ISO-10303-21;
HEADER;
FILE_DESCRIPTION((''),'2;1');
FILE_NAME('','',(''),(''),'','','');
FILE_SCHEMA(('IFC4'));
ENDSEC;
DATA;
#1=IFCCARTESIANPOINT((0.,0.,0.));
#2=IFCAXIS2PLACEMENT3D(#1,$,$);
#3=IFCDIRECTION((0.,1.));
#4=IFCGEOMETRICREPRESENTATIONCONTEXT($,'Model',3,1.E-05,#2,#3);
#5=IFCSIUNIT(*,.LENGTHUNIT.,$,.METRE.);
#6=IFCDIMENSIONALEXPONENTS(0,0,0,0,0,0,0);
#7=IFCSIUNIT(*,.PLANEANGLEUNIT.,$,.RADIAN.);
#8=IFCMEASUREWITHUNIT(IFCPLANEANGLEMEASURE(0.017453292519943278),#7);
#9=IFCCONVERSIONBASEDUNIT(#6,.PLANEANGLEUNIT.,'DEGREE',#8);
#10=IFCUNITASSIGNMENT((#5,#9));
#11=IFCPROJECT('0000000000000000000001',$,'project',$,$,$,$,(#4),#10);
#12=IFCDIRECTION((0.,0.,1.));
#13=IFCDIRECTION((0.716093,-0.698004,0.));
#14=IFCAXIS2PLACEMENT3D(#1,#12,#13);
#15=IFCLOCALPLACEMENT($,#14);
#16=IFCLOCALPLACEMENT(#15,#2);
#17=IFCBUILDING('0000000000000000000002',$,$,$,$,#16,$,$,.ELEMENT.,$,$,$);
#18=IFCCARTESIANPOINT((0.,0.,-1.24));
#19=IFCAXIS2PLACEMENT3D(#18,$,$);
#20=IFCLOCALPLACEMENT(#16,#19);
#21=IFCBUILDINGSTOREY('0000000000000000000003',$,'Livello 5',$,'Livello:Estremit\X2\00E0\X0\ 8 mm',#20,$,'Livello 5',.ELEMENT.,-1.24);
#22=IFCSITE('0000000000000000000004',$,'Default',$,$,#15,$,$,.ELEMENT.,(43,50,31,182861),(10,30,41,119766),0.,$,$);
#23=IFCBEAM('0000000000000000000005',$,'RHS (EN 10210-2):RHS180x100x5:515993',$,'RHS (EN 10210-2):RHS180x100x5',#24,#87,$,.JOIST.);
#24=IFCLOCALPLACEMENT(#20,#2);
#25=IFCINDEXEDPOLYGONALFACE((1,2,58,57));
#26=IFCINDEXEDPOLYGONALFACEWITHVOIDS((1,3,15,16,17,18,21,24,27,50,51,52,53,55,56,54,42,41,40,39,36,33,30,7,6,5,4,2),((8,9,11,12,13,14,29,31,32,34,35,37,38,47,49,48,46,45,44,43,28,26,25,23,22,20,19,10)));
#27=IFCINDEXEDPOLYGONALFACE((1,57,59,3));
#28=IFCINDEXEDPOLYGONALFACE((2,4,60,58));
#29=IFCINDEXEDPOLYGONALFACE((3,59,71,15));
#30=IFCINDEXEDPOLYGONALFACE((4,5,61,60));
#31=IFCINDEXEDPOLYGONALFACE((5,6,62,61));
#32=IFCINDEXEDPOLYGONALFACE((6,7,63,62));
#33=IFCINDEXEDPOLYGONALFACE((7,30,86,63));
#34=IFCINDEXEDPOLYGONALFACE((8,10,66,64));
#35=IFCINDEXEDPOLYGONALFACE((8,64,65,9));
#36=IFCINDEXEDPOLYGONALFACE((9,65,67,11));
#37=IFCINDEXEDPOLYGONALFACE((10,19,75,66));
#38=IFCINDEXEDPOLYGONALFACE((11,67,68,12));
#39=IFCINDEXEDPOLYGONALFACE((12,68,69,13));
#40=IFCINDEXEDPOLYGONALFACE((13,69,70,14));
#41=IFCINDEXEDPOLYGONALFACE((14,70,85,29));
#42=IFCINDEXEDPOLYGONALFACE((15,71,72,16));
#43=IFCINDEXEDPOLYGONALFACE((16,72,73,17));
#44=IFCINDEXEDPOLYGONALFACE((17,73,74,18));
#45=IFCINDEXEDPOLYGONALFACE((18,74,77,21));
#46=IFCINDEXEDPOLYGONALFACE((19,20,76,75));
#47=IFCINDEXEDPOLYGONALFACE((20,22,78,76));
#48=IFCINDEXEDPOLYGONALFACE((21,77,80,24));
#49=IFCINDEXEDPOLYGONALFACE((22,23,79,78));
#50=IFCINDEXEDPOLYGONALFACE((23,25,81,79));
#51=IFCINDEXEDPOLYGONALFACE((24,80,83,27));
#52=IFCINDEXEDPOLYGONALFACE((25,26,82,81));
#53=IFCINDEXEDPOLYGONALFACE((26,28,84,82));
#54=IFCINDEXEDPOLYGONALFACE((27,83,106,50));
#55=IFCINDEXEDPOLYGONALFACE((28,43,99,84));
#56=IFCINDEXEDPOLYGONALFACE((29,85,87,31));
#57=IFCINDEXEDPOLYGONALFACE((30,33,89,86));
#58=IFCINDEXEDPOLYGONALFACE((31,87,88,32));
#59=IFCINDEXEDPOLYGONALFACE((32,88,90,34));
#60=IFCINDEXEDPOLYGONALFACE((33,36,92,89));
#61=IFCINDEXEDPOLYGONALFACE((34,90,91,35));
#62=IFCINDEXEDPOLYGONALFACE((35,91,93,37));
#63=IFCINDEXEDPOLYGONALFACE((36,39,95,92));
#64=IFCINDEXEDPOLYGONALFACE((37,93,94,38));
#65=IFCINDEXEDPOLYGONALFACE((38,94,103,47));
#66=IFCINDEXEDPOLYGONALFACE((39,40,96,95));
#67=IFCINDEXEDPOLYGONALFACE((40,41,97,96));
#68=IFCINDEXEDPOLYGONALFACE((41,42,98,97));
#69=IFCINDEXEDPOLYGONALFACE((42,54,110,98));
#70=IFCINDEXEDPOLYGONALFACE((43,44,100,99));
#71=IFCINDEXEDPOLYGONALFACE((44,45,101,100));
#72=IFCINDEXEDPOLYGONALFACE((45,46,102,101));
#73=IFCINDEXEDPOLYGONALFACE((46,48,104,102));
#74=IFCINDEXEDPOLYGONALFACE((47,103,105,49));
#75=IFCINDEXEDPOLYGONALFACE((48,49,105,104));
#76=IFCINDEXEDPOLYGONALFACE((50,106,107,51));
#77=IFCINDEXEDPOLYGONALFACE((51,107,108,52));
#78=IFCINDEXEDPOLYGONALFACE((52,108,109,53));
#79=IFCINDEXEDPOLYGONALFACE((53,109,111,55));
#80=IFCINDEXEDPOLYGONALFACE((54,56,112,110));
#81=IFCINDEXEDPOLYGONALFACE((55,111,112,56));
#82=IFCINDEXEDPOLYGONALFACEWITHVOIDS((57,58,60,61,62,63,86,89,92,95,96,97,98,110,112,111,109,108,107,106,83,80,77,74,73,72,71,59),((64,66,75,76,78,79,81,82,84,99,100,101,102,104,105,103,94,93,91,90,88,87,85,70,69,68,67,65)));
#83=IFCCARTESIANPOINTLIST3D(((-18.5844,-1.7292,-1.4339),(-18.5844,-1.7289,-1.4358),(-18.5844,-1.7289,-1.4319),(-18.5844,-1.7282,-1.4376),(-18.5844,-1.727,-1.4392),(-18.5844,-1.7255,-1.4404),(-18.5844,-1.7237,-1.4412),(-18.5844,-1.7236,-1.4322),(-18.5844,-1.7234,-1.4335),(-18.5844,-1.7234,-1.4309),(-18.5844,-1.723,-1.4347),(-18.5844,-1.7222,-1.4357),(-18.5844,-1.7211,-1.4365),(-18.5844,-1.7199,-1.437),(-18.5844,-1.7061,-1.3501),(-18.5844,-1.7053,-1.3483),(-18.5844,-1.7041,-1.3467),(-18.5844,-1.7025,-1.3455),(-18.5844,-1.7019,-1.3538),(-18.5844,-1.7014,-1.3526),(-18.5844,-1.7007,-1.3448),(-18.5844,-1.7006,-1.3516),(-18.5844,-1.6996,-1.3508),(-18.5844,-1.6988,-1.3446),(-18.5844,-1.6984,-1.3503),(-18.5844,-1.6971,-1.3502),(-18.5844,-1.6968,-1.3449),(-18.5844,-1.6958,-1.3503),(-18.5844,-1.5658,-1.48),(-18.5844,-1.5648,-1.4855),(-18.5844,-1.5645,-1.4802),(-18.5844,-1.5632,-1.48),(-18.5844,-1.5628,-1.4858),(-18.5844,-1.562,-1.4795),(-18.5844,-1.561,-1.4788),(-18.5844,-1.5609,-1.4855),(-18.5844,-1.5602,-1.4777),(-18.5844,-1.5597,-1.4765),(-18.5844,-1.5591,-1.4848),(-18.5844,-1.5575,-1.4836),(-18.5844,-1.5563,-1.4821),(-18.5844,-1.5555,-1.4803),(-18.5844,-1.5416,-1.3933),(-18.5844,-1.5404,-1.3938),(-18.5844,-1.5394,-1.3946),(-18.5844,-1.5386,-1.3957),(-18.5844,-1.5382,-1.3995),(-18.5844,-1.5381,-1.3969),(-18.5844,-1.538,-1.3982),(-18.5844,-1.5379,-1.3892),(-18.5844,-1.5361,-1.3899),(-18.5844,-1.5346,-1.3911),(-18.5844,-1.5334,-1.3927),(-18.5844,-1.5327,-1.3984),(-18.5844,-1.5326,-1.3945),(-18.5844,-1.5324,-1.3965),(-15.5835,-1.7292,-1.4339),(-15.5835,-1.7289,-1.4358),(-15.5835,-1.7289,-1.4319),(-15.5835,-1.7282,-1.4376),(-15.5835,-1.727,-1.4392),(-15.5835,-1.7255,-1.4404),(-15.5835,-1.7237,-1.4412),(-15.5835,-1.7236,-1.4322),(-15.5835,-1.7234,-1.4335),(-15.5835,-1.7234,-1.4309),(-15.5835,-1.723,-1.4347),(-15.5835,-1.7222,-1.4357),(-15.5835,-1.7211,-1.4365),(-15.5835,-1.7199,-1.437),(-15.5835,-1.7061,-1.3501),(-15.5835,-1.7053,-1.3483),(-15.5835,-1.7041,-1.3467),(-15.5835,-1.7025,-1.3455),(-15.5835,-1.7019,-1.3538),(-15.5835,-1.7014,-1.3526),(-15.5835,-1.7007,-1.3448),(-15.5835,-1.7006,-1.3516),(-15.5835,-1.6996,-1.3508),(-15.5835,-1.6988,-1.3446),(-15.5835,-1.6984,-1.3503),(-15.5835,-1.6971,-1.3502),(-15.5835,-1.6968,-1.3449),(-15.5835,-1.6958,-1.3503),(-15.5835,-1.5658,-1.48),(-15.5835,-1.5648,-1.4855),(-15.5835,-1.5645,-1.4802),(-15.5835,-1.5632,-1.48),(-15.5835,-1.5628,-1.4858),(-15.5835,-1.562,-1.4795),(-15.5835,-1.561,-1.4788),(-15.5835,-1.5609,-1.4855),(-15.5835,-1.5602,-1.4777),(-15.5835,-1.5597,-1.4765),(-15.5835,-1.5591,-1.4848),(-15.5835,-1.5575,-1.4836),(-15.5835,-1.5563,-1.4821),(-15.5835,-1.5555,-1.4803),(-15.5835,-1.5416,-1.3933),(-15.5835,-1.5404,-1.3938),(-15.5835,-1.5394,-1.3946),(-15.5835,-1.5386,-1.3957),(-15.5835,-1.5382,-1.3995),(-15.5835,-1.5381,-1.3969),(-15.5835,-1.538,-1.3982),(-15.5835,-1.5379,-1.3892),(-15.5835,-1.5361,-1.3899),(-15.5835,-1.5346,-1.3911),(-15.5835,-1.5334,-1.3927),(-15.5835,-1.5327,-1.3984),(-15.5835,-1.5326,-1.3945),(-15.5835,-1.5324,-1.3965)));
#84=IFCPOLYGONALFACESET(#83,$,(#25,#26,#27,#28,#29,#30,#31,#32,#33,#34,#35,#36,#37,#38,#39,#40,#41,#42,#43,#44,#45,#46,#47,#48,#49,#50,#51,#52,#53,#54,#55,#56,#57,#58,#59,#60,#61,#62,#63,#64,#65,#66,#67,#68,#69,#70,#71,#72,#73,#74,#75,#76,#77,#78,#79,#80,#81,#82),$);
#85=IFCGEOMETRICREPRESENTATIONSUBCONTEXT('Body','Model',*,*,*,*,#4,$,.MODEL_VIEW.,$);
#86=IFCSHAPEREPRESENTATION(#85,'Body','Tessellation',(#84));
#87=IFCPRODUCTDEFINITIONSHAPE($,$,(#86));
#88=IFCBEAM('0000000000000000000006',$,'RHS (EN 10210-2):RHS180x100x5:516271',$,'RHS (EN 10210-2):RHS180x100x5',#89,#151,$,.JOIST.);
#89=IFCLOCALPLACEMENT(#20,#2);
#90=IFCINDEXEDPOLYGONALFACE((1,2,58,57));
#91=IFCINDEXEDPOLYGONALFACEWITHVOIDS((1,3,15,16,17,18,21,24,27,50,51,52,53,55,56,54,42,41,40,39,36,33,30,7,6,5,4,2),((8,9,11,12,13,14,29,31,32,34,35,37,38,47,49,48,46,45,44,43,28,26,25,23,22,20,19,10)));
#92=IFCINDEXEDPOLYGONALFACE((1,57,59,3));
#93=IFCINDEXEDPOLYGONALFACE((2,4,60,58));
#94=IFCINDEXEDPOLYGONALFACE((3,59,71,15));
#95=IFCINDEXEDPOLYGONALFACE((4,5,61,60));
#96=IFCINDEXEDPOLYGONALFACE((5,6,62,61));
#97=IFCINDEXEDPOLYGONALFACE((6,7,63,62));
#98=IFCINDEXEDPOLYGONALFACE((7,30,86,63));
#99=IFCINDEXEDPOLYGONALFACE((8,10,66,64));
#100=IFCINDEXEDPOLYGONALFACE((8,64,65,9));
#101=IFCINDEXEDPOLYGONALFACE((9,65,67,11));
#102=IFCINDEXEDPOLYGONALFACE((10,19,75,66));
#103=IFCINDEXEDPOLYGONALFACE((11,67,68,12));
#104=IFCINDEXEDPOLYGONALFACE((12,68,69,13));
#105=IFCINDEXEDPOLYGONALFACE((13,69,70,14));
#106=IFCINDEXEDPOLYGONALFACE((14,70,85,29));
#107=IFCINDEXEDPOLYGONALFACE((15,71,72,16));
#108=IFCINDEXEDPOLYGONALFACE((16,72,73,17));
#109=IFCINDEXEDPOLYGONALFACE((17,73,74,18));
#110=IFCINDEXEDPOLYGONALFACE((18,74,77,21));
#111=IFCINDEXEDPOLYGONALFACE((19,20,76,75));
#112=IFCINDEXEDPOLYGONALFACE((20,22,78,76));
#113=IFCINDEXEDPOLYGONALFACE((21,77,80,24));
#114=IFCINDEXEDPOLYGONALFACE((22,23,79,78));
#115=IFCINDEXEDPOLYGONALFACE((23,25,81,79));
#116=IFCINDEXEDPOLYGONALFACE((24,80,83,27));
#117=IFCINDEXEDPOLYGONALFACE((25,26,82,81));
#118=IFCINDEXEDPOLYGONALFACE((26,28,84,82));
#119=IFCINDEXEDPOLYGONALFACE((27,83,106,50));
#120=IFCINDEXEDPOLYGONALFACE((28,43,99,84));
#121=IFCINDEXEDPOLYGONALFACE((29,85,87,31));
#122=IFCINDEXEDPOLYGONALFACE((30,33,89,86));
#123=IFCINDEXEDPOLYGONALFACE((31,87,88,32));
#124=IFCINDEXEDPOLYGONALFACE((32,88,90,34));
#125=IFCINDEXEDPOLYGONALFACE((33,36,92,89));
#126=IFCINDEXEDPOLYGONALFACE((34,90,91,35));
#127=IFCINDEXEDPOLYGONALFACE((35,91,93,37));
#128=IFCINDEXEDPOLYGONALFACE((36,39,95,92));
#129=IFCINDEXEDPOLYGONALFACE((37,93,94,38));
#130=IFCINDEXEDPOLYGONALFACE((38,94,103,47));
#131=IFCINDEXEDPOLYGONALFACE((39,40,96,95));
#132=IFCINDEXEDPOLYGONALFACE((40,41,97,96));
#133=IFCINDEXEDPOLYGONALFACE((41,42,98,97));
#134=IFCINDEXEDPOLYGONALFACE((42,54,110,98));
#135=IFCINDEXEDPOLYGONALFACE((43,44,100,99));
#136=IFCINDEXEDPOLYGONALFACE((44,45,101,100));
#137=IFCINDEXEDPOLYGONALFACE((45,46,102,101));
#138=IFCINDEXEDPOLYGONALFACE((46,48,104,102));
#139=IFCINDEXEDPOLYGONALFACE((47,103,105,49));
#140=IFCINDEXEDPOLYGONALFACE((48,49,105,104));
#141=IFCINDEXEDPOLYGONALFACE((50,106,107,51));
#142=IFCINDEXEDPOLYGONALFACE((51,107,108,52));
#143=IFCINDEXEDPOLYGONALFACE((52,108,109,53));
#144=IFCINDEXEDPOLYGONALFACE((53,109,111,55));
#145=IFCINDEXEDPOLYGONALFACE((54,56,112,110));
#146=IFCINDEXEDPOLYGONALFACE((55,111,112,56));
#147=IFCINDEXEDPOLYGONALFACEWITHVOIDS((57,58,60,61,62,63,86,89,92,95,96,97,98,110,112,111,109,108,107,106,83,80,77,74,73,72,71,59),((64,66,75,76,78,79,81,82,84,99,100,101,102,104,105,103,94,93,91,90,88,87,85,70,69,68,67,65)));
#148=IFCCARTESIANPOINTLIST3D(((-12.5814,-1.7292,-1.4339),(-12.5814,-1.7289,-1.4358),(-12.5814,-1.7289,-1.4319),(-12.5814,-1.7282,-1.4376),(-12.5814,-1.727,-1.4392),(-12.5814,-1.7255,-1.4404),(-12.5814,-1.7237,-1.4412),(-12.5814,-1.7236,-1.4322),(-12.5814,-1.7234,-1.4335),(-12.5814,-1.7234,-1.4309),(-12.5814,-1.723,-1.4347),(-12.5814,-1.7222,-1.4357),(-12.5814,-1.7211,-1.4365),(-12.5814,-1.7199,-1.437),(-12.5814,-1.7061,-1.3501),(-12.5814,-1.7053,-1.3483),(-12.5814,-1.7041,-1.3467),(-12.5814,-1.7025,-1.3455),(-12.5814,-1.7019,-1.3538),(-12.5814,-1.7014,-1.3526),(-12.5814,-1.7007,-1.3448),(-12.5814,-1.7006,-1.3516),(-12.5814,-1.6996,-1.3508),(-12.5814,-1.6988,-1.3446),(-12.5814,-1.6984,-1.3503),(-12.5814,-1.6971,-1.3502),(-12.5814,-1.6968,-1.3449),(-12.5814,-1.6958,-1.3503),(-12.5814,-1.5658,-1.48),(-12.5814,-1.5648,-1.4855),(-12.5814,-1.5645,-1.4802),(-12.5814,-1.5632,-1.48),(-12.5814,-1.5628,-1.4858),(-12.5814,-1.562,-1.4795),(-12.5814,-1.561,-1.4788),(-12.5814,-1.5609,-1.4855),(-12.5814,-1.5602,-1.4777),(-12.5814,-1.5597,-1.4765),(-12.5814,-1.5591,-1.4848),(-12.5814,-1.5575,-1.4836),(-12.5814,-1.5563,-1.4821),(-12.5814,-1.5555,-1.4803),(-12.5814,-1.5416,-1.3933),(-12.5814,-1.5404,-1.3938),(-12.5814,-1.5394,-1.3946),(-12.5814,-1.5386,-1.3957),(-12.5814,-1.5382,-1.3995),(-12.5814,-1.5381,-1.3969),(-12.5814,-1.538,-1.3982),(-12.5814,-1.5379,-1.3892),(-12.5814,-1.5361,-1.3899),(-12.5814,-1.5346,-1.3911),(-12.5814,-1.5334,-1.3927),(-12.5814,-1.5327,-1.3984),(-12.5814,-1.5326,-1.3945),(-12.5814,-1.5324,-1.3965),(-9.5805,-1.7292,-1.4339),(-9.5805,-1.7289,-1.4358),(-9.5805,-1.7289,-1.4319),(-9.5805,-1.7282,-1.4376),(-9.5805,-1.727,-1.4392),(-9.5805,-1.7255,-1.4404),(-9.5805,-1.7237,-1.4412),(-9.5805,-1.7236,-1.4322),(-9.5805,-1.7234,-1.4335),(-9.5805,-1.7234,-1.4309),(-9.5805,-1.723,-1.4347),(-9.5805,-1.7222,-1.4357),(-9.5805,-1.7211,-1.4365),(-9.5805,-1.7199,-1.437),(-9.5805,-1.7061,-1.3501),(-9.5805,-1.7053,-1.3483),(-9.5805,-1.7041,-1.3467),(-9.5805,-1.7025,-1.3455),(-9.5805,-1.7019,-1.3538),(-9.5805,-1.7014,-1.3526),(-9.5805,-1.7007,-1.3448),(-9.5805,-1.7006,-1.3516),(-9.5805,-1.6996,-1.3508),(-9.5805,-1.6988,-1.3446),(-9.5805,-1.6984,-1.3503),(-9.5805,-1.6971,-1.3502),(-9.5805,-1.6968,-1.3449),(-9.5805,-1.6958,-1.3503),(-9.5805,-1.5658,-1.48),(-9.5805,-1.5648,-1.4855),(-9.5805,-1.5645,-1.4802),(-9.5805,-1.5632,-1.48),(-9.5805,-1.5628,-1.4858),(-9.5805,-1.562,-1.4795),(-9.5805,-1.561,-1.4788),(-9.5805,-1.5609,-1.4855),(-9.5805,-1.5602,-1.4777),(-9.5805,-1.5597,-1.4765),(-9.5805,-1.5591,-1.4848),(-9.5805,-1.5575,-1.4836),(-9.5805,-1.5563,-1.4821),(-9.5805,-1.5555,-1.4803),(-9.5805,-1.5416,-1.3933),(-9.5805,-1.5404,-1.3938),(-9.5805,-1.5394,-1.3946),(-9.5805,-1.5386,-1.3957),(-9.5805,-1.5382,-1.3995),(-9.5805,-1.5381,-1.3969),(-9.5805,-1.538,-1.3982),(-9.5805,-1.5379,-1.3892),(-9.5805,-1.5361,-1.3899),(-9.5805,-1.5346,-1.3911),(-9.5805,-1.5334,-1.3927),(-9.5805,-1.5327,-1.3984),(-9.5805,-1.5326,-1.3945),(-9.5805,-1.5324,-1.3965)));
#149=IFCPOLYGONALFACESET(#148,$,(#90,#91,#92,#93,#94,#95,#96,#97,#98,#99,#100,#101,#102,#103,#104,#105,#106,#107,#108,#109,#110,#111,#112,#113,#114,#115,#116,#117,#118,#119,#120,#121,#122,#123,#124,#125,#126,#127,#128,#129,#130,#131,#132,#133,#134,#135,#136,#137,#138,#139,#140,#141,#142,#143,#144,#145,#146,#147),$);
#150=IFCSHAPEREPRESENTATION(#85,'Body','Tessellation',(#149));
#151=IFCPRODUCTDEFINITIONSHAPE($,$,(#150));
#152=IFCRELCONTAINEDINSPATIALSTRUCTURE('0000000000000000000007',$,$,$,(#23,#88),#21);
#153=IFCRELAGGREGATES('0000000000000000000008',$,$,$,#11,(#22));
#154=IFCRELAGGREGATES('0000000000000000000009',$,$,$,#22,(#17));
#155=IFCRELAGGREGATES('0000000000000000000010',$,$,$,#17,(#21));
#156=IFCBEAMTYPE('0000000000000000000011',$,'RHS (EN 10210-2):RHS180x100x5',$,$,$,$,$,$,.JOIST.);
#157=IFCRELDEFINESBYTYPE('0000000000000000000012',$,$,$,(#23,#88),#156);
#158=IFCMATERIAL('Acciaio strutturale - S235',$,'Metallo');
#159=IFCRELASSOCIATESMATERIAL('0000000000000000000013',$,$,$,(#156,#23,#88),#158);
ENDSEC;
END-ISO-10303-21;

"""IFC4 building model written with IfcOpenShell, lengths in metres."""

from ifc_helpers import new_model, entity, si_unit, converted_unit, direction, frame, origin, place, context, subcontext, project, spatial, line, arc, indexed_curve, outline, extrude, source, transform, mapped, material, type_object, type_shapes, element, save


model = new_model("IFC4")

# Units and contexts
model_context = context("Model", 3, precision=1e-05, world=origin(), true_north=direction((0.0, 1.0)))
body_context = subcontext(model_context, "Body", "Model", "MODEL_VIEW")
ifc_project = project(units=[si_unit("LENGTHUNIT", "METRE"), converted_unit("PLANEANGLEUNIT", "DEGREE", entity("IfcPlaneAngleMeasure", 0.017453292519943278), si_unit("PLANEANGLEUNIT", "RADIAN"), dimensions=[0, 0, 0, 0, 0, 0, 0])], contexts=[model_context])

# Site, building, storey
site_placement = place(None, frame((0.0, 0.0, 0.0), z_axis=(0.0, 0.0, 1.0), x_axis=(0.716093, -0.698004, 0.0)))
site = spatial("IfcSite", under=ifc_project, at=site_placement, Name="Default", CompositionType="ELEMENT", RefLatitude=(43, 50, 31, 182861), RefLongitude=(10, 30, 41, 119766), RefElevation=0.0)
building_placement = place(site_placement, origin())
building = spatial("IfcBuilding", under=site, at=building_placement, CompositionType="ELEMENT")
storey_placement = place(building_placement, frame((0.0, 0.0, -1.24)))
storey = spatial("IfcBuildingStorey", under=building, at=storey_placement, Name="Livello 5", ObjectType="Livello:Estremità 8 mm", LongName="Livello 5", CompositionType="ELEMENT", Elevation=-1.24)

# Beams
ifc_material = material(Name="Acciaio strutturale - S235", Category="Metallo")
beam_type_1 = type_object("IfcBeamType", Name="RHS (EN 10210-2):RHS180x100x5", PredefinedType="JOIST", material=ifc_material)
shared_shape_1 = source(origin(), body_context, "Body", "SweptSolid", [
    extrude(outline(indexed_curve([(-0.05, -0.0825), (-0.0478, -0.0878), (-0.0425, -0.09), (0.0425, -0.09), (0.0478, -0.0878), (0.05, -0.0825), (0.05, 0.0825), (0.0478, 0.0878), (0.0425, 0.09), (-0.0425, 0.09), (-0.0478, 0.0878), (-0.05, 0.0825)], segments=[arc(1, 2, 3), line(3, 4), arc(4, 5, 6), line(6, 7), arc(7, 8, 9), line(9, 10), arc(10, 11, 12), line(12, 1)], self_intersect=False), holes=[indexed_curve([(0.04, -0.085), (-0.04, -0.085), (-0.0435, -0.0835), (-0.045, -0.08), (-0.045, 0.08), (-0.0435, 0.0835), (-0.04, 0.085), (0.04, 0.085), (0.0435, 0.0835), (0.045, 0.08), (0.045, -0.08), (0.0435, -0.0835)], segments=[line(1, 2), arc(2, 3, 4), line(4, 5), arc(5, 6, 7), line(7, 8), arc(8, 9, 10), line(10, 11), arc(11, 12, 1)], self_intersect=False)]), frame((-1.5005, 0.0, 0.0), z_axis=(1.0, 0.0, 0.0), x_axis=(0.0, -1.0, 0.0)), (0.0, 0.0, 1.0), 3.0009),
])
type_shapes(beam_type_1, [shared_shape_1])
for number, where, z_axis, x_axis, name in (
    (1, (-17.0839, -1.6308, -1.4152), (0.0, 0.963256, -0.268584), (-1.0, 0.0, 0.0), "RHS (EN 10210-2):RHS180x100x5:515993"),
    (2, (-11.0809, -1.6308, -1.4152), (0.0, 0.963256, -0.268584), (-1.0, 0.0, 0.0), "RHS (EN 10210-2):RHS180x100x5:516271"),
):
    element("IfcBeam", number, at=place(storey_placement, frame(where, z_axis=z_axis, x_axis=x_axis)), inside=storey, type_object=beam_type_1, material=ifc_material, Name=name, ObjectType="RHS (EN 10210-2):RHS180x100x5", PredefinedType="JOIST", context=body_context, shape_type="MappedRepresentation", body=[
        mapped(shared_shape_1, transform((0.0, 0.0, 0.0), scale=1.0)),
    ])

save(model, "model.ifc")
